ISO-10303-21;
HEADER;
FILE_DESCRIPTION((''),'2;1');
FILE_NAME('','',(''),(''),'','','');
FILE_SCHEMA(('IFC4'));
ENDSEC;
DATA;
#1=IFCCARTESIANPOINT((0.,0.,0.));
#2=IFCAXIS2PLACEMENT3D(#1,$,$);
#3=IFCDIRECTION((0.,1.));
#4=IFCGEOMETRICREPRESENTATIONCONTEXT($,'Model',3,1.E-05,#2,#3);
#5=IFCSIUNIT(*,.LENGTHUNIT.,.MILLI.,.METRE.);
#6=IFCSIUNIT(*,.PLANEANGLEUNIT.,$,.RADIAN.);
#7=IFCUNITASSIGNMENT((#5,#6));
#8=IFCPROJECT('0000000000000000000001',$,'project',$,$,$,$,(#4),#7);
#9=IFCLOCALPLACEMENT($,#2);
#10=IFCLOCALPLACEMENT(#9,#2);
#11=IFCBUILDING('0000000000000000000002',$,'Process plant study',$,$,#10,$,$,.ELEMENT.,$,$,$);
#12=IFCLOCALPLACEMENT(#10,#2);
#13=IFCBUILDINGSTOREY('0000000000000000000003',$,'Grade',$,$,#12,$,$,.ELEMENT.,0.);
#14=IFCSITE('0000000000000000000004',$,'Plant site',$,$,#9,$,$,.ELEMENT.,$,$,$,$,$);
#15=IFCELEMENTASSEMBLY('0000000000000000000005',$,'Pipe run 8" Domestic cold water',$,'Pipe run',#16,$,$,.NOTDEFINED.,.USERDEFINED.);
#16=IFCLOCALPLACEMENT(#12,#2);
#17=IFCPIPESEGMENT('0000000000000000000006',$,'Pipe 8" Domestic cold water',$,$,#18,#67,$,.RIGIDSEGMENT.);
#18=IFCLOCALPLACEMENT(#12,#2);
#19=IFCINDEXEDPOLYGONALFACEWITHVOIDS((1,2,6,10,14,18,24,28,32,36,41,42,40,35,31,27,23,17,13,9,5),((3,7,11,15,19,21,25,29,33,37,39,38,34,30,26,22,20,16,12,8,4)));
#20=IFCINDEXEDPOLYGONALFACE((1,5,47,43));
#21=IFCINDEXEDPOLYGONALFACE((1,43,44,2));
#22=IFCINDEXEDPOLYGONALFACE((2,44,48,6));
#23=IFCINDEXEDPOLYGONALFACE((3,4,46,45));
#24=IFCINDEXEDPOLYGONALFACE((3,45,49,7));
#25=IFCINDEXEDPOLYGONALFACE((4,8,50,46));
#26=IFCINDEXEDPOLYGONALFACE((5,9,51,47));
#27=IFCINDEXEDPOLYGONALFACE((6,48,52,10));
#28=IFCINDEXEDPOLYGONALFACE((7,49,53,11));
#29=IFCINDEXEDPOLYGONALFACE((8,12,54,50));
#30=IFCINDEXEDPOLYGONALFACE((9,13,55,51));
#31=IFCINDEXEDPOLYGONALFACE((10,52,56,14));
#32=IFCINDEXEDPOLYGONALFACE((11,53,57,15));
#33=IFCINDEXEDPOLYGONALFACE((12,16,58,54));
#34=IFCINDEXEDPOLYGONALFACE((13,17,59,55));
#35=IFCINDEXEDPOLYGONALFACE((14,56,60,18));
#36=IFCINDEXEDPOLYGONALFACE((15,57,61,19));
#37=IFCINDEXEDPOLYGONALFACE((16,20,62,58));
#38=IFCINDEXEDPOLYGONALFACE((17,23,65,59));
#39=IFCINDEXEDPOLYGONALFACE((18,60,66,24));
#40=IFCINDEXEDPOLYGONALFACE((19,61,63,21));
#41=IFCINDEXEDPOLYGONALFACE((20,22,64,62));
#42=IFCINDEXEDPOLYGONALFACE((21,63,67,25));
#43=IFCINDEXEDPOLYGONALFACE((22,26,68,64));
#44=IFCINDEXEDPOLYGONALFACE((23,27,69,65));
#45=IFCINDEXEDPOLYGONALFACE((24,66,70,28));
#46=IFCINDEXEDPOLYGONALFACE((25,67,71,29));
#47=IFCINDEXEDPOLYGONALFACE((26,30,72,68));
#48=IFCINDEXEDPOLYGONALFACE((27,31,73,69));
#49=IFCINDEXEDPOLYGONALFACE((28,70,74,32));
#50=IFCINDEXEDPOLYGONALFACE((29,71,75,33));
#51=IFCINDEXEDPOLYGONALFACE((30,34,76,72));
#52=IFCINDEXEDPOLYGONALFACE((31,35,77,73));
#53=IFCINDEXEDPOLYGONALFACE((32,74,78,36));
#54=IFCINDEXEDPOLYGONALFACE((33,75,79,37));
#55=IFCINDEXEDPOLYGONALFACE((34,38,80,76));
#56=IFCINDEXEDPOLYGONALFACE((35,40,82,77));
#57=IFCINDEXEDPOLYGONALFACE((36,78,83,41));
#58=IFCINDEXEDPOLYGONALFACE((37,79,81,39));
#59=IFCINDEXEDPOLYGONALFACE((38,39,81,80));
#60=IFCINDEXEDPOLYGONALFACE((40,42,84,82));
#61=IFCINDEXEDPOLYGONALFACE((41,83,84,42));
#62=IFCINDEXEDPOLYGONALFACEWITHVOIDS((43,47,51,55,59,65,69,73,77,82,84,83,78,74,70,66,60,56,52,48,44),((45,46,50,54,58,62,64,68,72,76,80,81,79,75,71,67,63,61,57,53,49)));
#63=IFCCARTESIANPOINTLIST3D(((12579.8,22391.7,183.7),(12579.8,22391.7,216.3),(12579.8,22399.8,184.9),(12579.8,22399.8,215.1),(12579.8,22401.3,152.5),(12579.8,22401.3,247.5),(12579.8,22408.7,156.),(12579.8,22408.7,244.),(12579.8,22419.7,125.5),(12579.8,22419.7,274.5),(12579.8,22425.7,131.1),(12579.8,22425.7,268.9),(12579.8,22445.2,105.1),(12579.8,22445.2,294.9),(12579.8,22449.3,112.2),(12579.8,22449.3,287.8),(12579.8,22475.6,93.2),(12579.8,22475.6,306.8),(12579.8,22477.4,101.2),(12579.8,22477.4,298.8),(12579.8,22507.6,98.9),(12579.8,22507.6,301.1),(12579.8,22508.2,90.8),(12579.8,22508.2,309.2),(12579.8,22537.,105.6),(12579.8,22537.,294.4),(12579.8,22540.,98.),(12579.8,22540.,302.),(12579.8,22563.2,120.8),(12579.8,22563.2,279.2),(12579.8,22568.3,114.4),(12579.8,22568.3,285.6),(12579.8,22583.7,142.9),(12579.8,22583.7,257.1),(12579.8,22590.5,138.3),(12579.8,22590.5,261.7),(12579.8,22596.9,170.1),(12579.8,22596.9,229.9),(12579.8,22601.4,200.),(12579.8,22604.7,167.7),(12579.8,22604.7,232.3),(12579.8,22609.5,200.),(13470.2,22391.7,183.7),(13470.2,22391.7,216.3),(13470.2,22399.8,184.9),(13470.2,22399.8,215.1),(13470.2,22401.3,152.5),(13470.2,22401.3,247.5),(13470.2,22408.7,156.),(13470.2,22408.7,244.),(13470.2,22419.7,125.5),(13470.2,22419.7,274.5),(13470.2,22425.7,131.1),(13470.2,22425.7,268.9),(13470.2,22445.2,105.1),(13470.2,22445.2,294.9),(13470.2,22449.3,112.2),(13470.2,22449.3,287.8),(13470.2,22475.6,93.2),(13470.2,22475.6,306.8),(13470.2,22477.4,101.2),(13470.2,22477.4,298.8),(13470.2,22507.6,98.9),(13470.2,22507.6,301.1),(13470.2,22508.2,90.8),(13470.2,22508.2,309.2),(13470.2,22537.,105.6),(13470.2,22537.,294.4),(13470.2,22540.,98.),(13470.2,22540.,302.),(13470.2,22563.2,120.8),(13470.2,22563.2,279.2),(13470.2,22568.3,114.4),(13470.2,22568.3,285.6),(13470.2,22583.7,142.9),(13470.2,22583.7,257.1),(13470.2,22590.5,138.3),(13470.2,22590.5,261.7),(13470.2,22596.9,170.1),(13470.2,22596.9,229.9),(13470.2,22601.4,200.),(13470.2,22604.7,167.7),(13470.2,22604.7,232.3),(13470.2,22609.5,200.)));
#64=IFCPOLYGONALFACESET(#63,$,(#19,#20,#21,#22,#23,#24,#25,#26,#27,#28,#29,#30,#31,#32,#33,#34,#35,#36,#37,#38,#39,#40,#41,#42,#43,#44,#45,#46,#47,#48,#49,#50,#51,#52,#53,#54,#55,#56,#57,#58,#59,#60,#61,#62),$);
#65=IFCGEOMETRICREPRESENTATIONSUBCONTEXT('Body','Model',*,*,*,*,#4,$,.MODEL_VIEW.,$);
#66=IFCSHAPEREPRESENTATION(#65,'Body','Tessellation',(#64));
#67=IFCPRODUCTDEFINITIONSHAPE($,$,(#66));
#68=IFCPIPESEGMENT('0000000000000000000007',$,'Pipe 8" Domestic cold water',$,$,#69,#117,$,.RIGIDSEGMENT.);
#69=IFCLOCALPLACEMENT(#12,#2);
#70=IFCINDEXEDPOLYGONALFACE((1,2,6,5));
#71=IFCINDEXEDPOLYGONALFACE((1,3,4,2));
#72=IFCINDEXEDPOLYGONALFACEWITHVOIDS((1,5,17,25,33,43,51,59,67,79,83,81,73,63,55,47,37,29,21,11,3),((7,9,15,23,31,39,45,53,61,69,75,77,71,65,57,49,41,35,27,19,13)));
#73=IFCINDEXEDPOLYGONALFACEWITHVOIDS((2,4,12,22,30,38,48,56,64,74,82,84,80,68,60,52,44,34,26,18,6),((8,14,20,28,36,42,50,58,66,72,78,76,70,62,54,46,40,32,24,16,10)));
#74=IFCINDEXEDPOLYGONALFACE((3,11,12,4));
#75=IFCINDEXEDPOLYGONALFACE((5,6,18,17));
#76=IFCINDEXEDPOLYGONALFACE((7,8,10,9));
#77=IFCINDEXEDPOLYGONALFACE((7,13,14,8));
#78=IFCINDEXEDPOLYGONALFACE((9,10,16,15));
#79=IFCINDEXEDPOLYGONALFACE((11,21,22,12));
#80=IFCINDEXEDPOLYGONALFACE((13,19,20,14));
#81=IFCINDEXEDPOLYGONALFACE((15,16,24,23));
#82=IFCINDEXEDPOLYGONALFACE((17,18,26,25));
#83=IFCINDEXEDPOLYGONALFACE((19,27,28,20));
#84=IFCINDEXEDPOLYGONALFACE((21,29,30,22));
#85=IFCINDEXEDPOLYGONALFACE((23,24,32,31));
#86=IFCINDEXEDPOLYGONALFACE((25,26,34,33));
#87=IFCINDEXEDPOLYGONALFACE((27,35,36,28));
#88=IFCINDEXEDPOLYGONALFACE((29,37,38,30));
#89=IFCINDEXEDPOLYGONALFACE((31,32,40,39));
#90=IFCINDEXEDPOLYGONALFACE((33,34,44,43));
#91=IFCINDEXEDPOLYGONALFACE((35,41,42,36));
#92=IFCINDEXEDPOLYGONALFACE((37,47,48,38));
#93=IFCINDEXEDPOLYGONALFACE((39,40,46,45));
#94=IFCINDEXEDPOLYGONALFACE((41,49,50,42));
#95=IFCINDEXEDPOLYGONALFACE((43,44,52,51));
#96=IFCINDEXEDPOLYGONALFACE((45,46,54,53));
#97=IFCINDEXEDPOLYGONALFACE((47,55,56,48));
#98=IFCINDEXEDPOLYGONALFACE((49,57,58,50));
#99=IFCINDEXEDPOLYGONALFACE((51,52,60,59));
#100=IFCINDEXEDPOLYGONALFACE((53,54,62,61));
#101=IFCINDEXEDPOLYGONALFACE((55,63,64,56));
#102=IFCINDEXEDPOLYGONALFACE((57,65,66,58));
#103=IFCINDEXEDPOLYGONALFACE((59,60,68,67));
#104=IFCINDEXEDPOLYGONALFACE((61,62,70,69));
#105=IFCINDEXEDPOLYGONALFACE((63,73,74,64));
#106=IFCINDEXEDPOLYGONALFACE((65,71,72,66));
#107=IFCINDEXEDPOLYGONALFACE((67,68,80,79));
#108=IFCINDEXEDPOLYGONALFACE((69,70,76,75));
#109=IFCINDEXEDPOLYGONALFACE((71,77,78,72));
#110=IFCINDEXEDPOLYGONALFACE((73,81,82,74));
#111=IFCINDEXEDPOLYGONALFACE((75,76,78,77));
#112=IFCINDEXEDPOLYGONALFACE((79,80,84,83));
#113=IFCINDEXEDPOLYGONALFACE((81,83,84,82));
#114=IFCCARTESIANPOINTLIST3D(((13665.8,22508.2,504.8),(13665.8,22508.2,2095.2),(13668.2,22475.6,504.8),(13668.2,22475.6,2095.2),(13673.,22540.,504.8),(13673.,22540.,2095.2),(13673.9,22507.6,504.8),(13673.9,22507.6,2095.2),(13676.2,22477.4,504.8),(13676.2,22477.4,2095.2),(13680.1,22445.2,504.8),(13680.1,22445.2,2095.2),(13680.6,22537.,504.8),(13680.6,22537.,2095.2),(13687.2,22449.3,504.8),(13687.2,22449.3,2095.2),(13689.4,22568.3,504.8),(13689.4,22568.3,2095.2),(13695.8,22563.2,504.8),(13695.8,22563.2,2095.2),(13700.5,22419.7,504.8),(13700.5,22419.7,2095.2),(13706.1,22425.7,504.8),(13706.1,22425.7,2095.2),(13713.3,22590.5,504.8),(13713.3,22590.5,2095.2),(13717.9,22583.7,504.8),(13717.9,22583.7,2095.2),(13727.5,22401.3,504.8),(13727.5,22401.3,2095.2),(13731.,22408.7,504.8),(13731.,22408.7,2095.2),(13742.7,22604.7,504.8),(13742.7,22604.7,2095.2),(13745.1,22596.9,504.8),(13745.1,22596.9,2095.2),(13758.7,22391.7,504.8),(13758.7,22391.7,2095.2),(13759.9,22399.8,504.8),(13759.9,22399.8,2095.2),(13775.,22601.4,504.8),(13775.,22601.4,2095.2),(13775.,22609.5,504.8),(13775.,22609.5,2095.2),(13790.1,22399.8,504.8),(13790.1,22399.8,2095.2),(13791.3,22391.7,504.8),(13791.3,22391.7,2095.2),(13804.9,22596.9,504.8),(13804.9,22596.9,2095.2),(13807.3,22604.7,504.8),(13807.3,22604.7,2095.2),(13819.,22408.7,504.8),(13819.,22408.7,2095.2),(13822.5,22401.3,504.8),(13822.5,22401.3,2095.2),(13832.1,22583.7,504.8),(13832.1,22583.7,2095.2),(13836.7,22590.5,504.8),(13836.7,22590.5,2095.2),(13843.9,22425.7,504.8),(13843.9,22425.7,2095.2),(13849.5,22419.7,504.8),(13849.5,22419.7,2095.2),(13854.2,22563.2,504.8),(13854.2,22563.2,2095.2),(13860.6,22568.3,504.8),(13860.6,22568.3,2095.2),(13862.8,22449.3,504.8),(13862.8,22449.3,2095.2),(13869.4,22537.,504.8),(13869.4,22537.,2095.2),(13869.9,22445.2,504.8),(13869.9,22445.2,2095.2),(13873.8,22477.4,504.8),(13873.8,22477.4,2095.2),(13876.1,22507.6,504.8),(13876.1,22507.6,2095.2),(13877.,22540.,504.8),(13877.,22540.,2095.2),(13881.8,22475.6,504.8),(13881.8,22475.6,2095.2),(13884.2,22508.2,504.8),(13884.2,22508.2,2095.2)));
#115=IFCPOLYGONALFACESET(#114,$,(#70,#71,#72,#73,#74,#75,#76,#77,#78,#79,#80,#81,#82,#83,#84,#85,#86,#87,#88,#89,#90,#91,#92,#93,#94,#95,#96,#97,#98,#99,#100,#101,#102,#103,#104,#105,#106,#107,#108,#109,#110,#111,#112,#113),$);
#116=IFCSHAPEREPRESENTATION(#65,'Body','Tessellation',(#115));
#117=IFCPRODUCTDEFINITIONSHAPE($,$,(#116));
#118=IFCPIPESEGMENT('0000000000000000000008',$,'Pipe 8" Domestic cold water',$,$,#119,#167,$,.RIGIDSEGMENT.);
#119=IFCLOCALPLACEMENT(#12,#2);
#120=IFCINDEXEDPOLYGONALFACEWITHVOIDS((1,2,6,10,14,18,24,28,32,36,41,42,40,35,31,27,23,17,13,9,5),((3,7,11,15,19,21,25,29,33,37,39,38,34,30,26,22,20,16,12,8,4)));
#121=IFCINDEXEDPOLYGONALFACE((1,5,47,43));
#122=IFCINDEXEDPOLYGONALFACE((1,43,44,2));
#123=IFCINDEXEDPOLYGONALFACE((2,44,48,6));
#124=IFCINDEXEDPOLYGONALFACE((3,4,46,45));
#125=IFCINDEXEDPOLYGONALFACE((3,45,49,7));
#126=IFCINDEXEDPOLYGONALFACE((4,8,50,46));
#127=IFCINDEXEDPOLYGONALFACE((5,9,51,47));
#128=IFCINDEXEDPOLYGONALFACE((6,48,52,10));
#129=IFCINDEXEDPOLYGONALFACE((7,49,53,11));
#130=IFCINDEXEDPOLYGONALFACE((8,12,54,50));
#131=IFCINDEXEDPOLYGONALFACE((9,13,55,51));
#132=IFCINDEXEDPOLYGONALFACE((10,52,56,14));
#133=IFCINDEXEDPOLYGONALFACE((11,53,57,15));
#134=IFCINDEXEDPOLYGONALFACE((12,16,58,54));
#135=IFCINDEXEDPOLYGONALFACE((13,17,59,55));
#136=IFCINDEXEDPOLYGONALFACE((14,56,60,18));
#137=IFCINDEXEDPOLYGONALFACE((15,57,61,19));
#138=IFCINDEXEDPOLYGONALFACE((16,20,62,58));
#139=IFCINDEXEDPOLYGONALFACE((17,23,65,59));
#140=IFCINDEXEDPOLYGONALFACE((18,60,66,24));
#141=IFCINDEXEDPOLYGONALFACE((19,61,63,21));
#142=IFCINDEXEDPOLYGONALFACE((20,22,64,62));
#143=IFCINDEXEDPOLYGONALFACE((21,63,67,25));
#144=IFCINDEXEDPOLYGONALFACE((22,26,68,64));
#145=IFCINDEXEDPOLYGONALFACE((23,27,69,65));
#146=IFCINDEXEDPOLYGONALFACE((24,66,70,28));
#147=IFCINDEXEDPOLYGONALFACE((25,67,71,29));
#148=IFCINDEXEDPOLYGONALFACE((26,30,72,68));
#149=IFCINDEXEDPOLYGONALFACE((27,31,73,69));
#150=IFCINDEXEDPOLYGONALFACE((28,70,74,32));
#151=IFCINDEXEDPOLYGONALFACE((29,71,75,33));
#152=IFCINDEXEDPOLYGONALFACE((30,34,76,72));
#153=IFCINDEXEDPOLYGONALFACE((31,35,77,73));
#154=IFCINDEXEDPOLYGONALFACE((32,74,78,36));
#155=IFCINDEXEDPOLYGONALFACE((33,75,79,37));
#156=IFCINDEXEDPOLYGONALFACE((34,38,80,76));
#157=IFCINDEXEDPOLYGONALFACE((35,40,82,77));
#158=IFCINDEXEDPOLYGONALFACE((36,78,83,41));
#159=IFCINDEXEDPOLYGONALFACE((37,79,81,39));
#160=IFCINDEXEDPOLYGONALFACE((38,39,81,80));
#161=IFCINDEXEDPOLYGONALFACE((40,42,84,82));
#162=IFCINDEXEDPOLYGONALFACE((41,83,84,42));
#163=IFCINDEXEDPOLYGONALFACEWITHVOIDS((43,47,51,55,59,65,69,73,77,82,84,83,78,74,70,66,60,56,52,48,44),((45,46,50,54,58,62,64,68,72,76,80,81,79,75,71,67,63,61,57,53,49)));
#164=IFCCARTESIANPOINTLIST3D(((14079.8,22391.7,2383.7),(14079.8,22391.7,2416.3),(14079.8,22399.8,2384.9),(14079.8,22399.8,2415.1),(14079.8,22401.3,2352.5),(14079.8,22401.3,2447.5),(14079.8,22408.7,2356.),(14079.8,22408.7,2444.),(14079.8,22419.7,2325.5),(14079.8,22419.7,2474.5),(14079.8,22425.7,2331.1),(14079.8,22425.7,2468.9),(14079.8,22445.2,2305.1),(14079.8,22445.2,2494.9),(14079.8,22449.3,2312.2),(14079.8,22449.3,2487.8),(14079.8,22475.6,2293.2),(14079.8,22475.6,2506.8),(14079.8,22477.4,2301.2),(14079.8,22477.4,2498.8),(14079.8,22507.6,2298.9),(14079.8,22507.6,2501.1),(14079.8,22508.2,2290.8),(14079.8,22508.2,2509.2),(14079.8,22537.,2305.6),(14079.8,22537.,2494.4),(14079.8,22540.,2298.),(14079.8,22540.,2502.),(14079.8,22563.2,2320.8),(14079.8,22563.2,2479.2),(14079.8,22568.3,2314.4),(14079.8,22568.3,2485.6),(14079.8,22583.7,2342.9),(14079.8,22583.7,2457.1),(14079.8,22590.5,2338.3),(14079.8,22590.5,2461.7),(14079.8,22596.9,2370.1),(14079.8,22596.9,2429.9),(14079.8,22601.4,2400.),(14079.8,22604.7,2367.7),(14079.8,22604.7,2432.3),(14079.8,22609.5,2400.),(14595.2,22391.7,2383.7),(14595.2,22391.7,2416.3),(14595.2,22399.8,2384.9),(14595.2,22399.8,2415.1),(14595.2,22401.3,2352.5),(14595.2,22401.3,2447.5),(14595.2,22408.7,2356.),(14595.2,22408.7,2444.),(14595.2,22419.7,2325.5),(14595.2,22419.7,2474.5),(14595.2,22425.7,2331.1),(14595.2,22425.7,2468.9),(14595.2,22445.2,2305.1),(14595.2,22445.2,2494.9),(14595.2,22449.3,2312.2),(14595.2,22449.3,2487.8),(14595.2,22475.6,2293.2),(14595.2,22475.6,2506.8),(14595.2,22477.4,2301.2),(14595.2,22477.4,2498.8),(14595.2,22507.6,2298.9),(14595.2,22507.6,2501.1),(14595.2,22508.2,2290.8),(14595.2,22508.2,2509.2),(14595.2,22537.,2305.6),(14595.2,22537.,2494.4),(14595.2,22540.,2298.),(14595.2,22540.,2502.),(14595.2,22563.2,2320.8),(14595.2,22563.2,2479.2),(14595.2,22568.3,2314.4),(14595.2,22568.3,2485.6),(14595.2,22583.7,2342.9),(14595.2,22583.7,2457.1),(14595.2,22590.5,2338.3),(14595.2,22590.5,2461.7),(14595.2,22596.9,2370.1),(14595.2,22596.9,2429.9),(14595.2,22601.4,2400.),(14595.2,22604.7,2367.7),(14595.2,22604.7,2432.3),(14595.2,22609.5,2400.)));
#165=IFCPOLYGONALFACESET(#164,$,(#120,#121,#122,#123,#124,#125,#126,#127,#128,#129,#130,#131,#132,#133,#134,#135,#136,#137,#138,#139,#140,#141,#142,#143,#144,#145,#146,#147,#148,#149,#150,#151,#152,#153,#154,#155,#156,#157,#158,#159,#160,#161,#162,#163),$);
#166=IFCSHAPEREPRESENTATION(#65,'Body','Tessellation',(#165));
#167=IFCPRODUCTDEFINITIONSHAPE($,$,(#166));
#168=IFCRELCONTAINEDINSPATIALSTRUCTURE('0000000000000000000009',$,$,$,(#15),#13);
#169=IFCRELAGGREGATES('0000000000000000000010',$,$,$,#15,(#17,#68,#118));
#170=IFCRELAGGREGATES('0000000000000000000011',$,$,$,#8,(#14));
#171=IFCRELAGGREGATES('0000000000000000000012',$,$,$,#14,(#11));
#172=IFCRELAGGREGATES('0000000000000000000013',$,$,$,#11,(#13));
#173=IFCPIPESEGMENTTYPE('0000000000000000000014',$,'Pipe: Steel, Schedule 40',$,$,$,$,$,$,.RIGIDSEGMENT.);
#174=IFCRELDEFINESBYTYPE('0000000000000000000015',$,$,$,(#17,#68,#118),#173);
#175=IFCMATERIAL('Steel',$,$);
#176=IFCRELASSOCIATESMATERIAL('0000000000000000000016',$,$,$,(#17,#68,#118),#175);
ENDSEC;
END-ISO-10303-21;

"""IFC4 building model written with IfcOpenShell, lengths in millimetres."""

from ifc_helpers import new_model, si_unit, direction, frame, origin, origin_with_axes, origin_2d, place, context, subcontext, project, spatial, hollow_circle, extrude, material, type_object, element, aggregate, save


model = new_model("IFC4")

# Units and contexts
model_context = context("Model", 3, precision=1e-05, world=origin(), true_north=direction((0.0, 1.0)))
body_context = subcontext(model_context, "Body", "Model", "MODEL_VIEW")
ifc_project = project(units=[si_unit("LENGTHUNIT", "METRE", prefix="MILLI"), si_unit("PLANEANGLEUNIT", "RADIAN")], contexts=[model_context])

# Site, building, storey
site_placement = place(None, origin())
site = spatial("IfcSite", under=ifc_project, at=site_placement, Name="Plant site", CompositionType="ELEMENT")
building_placement = place(site_placement, origin())
building = spatial("IfcBuilding", under=site, at=building_placement, Name="Process plant study", CompositionType="ELEMENT")
storey_placement = place(building_placement, origin())
storey = spatial("IfcBuildingStorey", under=building, at=storey_placement, Name="Grade", CompositionType="ELEMENT", Elevation=0.0)

# Element assembly, pipe segments
ifc_material = material(Name="Steel")
pipe_segment_type = type_object("IfcPipeSegmentType", Name="Pipe: Steel, Schedule 40", PredefinedType="RIGIDSEGMENT")
assembly_1_placement = place(storey_placement, origin_with_axes())
assembly_1 = element("IfcElementAssembly", 1, at=assembly_1_placement, inside=storey, Name="Pipe run 8\" Domestic cold water", ObjectType="Pipe run", AssemblyPlace="NOTDEFINED", PredefinedType="USERDEFINED")
pipe_segment_1_placement = place(storey_placement, origin_with_axes())
pipe_segment_1 = element("IfcPipeSegment", 2, at=pipe_segment_1_placement, type_object=pipe_segment_type, material=ifc_material, Name="Pipe 8\" Domestic cold water", PredefinedType="RIGIDSEGMENT", context=body_context, shape_type="SweptSolid", body=[
    extrude(hollow_circle(Radius=109.5, WallThickness=8.2, at=origin_2d()), frame((12579.8, 22500.0, 200.0), z_axis=(1.0, 0.0, 0.0), x_axis=(0.0, 1.0, 0.0)), (0.0, 0.0, 1.0), 890.4),
])
pipe_segment_2_placement = place(storey_placement, origin_with_axes())
pipe_segment_2 = element("IfcPipeSegment", 3, at=pipe_segment_2_placement, type_object=pipe_segment_type, material=ifc_material, Name="Pipe 8\" Domestic cold water", PredefinedType="RIGIDSEGMENT", context=body_context, shape_type="SweptSolid", body=[
    extrude(hollow_circle(Radius=109.5, WallThickness=8.2, at=origin_2d()), frame((13775.0, 22500.0, 504.8), z_axis=(0.0, 0.0, 1.0), x_axis=(0.0, 1.0, 0.0)), (0.0, 0.0, 1.0), 1590.4),
])
pipe_segment_3_placement = place(storey_placement, origin_with_axes())
pipe_segment_3 = element("IfcPipeSegment", 4, at=pipe_segment_3_placement, type_object=pipe_segment_type, material=ifc_material, Name="Pipe 8\" Domestic cold water", PredefinedType="RIGIDSEGMENT", context=body_context, shape_type="SweptSolid", body=[
    extrude(hollow_circle(Radius=109.5, WallThickness=8.2, at=origin_2d()), frame((14079.8, 22500.0, 2400.0), z_axis=(1.0, 0.0, 0.0), x_axis=(0.0, 1.0, 0.0)), (0.0, 0.0, 1.0), 515.4),
])

aggregate(assembly_1, [pipe_segment_1, pipe_segment_2, pipe_segment_3])

save(model, "model.ifc")
